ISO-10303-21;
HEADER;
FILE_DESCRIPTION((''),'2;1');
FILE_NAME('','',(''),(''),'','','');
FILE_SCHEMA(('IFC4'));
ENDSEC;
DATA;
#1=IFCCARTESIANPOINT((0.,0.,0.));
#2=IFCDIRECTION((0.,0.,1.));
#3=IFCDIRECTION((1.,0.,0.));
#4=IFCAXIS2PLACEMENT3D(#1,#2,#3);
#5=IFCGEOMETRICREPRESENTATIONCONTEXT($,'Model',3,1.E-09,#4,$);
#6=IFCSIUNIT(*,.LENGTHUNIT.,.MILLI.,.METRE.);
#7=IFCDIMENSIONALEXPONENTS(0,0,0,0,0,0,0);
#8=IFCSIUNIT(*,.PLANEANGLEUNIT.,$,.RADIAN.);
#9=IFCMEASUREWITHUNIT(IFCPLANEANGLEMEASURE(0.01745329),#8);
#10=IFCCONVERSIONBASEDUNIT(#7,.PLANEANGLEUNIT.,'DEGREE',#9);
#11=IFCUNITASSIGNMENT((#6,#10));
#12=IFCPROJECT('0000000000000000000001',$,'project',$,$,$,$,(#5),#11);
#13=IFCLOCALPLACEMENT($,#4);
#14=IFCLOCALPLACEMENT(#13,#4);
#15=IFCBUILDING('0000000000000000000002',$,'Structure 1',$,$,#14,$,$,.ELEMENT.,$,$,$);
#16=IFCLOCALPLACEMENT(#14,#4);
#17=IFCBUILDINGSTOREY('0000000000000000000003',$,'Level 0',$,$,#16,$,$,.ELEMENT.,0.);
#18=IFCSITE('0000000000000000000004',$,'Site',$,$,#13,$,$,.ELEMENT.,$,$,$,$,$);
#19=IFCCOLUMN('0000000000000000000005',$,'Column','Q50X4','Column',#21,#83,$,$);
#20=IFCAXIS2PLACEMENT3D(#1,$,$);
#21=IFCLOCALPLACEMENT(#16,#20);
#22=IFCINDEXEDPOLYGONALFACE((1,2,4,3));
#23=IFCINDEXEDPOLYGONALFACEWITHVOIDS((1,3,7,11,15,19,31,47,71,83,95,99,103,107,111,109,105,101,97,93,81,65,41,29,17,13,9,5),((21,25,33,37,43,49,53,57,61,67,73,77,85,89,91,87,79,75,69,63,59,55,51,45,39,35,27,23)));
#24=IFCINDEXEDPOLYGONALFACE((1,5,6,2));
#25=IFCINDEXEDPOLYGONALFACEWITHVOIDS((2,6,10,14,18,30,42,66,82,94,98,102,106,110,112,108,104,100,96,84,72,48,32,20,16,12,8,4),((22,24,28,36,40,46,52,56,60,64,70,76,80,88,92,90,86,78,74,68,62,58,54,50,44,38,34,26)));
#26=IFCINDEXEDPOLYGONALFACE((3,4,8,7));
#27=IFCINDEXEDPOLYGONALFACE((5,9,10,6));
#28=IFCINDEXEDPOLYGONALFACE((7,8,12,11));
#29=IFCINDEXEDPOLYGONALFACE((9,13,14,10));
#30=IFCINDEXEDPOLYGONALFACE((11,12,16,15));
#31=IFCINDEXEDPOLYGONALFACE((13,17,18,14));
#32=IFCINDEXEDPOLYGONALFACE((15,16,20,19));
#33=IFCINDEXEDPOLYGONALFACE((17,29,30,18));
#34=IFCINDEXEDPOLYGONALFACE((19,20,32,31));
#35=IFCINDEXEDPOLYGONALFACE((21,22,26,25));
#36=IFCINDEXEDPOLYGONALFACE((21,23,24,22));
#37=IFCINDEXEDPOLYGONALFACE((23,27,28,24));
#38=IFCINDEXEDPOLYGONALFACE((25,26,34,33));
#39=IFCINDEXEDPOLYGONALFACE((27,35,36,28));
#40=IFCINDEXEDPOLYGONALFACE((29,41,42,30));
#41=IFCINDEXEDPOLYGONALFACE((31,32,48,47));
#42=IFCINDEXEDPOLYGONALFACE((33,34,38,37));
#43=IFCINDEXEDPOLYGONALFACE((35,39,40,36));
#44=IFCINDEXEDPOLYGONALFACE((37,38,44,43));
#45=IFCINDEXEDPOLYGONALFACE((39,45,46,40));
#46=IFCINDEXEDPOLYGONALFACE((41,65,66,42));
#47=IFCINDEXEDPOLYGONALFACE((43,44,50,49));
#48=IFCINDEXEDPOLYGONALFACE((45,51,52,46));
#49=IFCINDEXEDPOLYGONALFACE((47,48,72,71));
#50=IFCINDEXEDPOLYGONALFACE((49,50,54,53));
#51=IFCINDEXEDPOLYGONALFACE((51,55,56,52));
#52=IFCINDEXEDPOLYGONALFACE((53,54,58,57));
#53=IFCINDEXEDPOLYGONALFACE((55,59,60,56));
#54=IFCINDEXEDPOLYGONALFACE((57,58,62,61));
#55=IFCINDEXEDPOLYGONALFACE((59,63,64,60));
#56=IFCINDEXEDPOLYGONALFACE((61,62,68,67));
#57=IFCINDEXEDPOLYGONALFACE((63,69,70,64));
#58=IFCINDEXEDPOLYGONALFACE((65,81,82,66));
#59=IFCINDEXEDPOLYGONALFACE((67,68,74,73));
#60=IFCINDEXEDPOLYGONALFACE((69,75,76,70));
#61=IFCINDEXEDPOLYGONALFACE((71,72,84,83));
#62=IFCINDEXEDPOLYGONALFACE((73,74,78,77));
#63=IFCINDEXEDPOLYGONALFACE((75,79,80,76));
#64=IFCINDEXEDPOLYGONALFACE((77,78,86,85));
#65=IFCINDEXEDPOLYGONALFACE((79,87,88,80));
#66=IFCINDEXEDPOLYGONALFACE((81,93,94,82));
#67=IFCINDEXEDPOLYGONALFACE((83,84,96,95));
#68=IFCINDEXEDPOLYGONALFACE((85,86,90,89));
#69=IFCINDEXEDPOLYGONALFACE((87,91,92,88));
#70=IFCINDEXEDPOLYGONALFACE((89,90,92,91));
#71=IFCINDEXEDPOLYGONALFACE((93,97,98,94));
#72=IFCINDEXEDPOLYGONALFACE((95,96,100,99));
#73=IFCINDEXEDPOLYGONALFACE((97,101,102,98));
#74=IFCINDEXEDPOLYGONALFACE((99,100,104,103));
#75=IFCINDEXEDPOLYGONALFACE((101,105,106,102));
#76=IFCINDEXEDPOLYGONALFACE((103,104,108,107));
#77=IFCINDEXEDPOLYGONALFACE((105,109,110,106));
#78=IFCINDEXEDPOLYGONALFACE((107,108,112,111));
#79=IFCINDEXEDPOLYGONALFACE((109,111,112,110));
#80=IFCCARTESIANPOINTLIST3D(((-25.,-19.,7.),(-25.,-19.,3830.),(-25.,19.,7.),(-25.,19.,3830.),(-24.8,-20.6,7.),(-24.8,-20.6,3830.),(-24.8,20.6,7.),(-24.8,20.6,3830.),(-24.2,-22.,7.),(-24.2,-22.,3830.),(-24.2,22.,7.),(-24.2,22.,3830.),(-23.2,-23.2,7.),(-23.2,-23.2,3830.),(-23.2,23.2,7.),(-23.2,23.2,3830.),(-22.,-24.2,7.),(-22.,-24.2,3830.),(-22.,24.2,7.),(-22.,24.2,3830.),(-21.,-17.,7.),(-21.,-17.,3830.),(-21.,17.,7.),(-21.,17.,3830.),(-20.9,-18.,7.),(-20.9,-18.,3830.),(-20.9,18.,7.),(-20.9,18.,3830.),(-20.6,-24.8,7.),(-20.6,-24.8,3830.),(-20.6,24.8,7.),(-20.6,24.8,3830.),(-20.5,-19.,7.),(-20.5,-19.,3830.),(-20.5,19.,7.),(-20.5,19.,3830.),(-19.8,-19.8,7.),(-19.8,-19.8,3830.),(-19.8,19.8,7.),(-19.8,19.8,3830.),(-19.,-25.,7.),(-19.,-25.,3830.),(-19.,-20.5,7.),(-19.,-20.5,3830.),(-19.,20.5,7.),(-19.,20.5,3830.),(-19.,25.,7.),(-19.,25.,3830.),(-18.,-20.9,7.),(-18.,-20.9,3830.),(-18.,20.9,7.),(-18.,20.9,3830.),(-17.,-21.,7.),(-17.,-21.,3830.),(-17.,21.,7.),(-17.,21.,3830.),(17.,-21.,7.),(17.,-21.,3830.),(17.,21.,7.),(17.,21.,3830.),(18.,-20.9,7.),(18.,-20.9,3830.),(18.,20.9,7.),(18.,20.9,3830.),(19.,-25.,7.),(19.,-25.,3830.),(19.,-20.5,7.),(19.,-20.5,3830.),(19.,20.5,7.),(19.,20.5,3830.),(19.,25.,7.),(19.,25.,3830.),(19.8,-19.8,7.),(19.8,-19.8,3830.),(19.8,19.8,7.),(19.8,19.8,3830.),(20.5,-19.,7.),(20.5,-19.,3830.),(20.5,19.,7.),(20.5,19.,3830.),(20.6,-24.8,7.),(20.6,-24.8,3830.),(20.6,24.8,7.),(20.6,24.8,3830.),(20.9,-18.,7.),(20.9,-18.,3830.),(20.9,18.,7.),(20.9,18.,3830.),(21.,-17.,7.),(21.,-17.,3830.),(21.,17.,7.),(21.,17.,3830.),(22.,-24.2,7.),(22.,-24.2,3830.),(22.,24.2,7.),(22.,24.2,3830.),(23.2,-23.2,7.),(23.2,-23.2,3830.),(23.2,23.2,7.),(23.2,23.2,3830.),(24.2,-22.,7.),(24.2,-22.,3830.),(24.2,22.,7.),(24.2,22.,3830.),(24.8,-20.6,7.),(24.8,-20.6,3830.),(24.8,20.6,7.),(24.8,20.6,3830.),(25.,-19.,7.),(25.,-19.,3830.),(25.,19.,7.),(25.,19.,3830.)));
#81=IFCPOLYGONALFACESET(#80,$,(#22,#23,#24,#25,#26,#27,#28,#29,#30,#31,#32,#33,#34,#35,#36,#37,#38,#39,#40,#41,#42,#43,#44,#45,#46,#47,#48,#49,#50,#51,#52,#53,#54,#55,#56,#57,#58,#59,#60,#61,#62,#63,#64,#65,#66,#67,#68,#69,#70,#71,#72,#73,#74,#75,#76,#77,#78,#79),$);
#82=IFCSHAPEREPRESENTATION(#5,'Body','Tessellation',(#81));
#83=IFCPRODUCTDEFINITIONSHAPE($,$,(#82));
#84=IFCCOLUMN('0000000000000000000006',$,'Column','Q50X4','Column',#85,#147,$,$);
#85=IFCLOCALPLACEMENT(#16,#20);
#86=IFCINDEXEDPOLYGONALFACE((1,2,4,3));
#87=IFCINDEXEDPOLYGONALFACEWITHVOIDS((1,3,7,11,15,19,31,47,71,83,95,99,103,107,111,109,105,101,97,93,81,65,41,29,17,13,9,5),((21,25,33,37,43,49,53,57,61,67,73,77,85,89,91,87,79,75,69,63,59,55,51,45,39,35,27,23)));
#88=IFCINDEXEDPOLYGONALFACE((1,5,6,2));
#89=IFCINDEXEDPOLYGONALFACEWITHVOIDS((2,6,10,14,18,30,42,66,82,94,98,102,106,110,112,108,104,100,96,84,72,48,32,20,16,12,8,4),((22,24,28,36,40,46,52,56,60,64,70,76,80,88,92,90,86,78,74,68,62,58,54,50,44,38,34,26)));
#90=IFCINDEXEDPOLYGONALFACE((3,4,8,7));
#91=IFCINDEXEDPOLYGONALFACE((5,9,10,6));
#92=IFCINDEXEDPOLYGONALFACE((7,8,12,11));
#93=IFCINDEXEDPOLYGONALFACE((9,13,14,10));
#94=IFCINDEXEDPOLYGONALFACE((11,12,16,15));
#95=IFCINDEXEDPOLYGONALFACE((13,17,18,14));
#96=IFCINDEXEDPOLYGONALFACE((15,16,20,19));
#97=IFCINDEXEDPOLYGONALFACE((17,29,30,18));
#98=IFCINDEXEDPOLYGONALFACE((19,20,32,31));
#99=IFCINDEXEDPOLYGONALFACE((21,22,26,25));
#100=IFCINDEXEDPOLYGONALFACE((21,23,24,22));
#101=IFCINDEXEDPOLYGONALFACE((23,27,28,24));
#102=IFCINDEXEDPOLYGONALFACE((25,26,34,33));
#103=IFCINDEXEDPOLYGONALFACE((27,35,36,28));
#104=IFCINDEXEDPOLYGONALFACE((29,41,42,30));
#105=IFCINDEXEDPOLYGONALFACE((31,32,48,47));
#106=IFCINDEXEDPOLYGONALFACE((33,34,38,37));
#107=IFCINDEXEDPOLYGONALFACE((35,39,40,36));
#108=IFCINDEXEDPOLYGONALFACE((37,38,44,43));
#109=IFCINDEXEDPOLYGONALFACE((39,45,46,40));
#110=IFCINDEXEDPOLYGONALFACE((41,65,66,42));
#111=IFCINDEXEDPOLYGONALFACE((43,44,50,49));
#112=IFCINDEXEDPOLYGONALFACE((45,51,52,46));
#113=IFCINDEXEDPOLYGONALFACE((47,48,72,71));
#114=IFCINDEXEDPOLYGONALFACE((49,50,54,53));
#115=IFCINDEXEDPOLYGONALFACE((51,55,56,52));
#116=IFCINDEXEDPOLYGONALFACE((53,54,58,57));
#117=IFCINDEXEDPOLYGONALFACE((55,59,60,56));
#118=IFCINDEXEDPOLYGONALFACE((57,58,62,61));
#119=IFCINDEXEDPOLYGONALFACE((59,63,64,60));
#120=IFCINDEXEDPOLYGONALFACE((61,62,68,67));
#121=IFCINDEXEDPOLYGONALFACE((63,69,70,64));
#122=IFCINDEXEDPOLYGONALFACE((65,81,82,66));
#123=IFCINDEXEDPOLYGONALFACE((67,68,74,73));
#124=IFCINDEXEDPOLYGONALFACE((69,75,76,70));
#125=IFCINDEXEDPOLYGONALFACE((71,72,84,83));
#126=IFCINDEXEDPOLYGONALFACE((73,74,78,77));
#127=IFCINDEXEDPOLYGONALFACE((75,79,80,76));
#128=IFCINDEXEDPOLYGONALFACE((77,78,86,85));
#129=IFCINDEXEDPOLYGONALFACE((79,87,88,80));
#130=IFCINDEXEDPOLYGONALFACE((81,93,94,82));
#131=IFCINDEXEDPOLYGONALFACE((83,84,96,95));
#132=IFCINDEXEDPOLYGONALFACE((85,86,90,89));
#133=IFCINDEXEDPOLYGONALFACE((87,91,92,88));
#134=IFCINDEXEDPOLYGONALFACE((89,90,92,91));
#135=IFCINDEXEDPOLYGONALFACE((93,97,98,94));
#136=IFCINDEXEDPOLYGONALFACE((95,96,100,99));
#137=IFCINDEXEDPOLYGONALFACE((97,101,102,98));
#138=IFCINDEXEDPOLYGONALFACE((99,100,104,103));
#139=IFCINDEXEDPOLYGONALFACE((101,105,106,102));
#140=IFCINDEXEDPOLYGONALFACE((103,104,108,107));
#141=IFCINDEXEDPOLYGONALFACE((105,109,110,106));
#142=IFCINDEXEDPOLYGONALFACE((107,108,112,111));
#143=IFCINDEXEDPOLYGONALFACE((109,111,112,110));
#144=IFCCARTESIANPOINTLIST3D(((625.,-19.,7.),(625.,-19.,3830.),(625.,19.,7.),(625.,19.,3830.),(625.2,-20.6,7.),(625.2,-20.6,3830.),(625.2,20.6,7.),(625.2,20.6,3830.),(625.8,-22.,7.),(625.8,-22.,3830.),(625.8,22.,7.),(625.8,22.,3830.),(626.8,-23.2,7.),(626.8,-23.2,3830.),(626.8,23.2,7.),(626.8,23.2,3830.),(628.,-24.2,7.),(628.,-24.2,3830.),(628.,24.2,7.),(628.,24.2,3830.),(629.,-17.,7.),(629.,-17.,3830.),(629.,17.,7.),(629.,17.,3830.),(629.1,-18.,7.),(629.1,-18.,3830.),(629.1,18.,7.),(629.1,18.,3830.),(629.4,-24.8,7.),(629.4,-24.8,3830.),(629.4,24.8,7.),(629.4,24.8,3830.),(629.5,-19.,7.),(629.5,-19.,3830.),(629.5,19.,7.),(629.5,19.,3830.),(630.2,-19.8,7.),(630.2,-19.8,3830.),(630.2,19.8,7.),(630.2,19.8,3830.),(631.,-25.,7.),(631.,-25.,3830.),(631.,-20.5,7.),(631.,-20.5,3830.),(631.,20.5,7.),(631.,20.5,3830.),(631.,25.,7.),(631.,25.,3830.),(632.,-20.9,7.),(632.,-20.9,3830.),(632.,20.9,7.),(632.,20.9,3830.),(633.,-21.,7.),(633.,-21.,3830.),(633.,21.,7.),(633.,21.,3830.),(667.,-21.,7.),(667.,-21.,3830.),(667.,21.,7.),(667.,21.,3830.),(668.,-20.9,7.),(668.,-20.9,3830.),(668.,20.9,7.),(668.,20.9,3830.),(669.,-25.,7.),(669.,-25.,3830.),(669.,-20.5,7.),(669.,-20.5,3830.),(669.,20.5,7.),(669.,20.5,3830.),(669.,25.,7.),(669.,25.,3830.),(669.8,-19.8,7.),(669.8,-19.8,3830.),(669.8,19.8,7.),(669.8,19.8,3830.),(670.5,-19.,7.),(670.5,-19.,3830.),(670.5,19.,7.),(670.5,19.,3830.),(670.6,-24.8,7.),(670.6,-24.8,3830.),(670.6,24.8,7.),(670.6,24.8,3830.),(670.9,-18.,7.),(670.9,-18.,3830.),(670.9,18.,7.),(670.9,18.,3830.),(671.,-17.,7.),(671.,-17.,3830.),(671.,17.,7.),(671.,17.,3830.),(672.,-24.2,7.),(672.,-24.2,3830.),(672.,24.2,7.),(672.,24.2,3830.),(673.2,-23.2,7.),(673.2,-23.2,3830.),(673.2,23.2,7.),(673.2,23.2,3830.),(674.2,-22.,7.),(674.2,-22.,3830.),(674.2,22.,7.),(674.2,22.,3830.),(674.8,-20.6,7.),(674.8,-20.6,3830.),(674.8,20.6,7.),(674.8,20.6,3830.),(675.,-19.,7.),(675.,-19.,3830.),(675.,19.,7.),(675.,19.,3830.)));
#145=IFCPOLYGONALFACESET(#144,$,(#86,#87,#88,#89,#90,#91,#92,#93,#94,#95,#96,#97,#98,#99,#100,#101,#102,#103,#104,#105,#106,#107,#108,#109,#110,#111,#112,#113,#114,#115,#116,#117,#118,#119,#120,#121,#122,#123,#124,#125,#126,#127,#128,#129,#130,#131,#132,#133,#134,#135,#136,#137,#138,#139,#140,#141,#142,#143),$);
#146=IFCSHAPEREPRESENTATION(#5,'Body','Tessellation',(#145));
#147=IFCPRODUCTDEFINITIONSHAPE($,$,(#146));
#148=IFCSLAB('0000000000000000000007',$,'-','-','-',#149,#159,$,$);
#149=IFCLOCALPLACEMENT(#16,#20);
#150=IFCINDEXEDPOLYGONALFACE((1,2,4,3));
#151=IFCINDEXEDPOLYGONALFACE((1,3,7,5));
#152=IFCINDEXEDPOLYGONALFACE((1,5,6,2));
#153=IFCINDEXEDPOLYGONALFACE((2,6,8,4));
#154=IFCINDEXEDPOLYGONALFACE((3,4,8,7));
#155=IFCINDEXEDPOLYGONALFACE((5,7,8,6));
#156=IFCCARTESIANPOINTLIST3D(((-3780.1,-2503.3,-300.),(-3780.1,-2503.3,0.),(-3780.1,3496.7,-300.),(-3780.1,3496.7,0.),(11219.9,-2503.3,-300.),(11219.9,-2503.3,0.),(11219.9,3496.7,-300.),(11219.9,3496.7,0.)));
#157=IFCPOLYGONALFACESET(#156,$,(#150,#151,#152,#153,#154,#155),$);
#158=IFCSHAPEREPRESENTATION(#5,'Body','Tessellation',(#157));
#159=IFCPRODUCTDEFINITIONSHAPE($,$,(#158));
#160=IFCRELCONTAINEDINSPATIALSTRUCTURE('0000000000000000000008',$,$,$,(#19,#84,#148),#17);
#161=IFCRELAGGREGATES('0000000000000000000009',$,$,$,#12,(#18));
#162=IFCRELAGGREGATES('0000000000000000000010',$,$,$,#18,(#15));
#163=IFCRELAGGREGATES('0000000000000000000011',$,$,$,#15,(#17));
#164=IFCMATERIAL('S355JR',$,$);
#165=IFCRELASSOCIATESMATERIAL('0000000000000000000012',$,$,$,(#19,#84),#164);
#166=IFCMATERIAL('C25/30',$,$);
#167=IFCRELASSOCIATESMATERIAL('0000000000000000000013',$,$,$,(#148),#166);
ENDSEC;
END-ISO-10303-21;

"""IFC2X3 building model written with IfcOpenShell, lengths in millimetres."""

from ifc_helpers import new_model, entity, si_unit, converted_unit, frame, origin, origin_with_axes, origin_2d, place, context, project, spatial, polyline, hollow_rectangle, outline, extrude, clip, halfspace, material, element, save


model = new_model("IFC2X3")

# Units and contexts
model_context = context("Model", 3, precision=1e-09, world=origin_with_axes())
ifc_project = project(units=[si_unit("LENGTHUNIT", "METRE", prefix="MILLI"), converted_unit("PLANEANGLEUNIT", "DEGREE", entity("IfcPlaneAngleMeasure", 0.01745329), si_unit("PLANEANGLEUNIT", "RADIAN"), dimensions=[0, 0, 0, 0, 0, 0, 0])], contexts=[model_context])

# Site, building, storey
site_placement = place(None, origin_with_axes())
site = spatial("IfcSite", under=ifc_project, at=site_placement, Name="Site", CompositionType="ELEMENT")
building_placement = place(site_placement, origin_with_axes())
building = spatial("IfcBuilding", under=site, at=building_placement, Name="Structure 1", CompositionType="ELEMENT")
storey_placement = place(building_placement, origin_with_axes())
storey = spatial("IfcBuildingStorey", under=building, at=storey_placement, Name="Level 0", CompositionType="ELEMENT", Elevation=0.0)

# Columns
ifc_material_1 = material(Name="S355JR")
column_1_placement = place(None, frame((0.0, 0.0, -35.4), z_axis=(0.0, 0.0, -1.0), x_axis=(-1.0, 0.0, 0.0)))
element("IfcColumn", 1, at=column_1_placement, inside=storey, material=ifc_material_1, Name="Column", Description="Q50X4", ObjectType="Column", context=model_context, shape_type="Clipping", body=[
    clip(extrude(hollow_rectangle(XDim=50.0, YDim=50.0, WallThickness=4.0, InnerFilletRadius=4.0, OuterFilletRadius=6.0, at=origin_2d()), origin(), (0.0, 0.0, -1.0), 3865.4), halfspace(frame((0.0, 0.0, -42.4), z_axis=(0.0, 0.0, -1.0), x_axis=(-1.0, 0.0, 0.0)), True)),
])
column_2_placement = place(None, frame((650.0, 0.0, -35.4), z_axis=(0.0, 0.0, -1.0), x_axis=(-1.0, 0.0, 0.0)))
element("IfcColumn", 2, at=column_2_placement, inside=storey, material=ifc_material_1, Name="Column", Description="Q50X4", ObjectType="Column", context=model_context, shape_type="Clipping", body=[
    clip(extrude(hollow_rectangle(XDim=50.0, YDim=50.0, WallThickness=4.0, InnerFilletRadius=4.0, OuterFilletRadius=6.0, at=origin_2d()), origin(), (0.0, 0.0, -1.0), 3865.4), halfspace(frame((650.0, 0.0, -42.4), z_axis=(0.0, 0.0, -1.0), x_axis=(-1.0, 0.0, 0.0)), True)),
])

# Slab
ifc_material_2 = material(Name="C25/30")
slab_placement = place(None, frame((3719.9, 496.7, -300.0), z_axis=(0.0, 0.0, 1.0), x_axis=(1.0, 0.0, 0.0)))
element("IfcSlab", 3, at=slab_placement, inside=storey, material=ifc_material_2, Name="-", Description="-", ObjectType="-", context=model_context, shape_type="SweptSolid", body=[
    extrude(outline(polyline([(-7500.0, -3000.0), (7500.0, -3000.0), (7500.0, 3000.0), (-7500.0, 3000.0), (-7500.0, -3000.0)])), origin_with_axes(), (0.0, 0.0, 1.0), 300.0),
])

save(model, "model.ifc")
